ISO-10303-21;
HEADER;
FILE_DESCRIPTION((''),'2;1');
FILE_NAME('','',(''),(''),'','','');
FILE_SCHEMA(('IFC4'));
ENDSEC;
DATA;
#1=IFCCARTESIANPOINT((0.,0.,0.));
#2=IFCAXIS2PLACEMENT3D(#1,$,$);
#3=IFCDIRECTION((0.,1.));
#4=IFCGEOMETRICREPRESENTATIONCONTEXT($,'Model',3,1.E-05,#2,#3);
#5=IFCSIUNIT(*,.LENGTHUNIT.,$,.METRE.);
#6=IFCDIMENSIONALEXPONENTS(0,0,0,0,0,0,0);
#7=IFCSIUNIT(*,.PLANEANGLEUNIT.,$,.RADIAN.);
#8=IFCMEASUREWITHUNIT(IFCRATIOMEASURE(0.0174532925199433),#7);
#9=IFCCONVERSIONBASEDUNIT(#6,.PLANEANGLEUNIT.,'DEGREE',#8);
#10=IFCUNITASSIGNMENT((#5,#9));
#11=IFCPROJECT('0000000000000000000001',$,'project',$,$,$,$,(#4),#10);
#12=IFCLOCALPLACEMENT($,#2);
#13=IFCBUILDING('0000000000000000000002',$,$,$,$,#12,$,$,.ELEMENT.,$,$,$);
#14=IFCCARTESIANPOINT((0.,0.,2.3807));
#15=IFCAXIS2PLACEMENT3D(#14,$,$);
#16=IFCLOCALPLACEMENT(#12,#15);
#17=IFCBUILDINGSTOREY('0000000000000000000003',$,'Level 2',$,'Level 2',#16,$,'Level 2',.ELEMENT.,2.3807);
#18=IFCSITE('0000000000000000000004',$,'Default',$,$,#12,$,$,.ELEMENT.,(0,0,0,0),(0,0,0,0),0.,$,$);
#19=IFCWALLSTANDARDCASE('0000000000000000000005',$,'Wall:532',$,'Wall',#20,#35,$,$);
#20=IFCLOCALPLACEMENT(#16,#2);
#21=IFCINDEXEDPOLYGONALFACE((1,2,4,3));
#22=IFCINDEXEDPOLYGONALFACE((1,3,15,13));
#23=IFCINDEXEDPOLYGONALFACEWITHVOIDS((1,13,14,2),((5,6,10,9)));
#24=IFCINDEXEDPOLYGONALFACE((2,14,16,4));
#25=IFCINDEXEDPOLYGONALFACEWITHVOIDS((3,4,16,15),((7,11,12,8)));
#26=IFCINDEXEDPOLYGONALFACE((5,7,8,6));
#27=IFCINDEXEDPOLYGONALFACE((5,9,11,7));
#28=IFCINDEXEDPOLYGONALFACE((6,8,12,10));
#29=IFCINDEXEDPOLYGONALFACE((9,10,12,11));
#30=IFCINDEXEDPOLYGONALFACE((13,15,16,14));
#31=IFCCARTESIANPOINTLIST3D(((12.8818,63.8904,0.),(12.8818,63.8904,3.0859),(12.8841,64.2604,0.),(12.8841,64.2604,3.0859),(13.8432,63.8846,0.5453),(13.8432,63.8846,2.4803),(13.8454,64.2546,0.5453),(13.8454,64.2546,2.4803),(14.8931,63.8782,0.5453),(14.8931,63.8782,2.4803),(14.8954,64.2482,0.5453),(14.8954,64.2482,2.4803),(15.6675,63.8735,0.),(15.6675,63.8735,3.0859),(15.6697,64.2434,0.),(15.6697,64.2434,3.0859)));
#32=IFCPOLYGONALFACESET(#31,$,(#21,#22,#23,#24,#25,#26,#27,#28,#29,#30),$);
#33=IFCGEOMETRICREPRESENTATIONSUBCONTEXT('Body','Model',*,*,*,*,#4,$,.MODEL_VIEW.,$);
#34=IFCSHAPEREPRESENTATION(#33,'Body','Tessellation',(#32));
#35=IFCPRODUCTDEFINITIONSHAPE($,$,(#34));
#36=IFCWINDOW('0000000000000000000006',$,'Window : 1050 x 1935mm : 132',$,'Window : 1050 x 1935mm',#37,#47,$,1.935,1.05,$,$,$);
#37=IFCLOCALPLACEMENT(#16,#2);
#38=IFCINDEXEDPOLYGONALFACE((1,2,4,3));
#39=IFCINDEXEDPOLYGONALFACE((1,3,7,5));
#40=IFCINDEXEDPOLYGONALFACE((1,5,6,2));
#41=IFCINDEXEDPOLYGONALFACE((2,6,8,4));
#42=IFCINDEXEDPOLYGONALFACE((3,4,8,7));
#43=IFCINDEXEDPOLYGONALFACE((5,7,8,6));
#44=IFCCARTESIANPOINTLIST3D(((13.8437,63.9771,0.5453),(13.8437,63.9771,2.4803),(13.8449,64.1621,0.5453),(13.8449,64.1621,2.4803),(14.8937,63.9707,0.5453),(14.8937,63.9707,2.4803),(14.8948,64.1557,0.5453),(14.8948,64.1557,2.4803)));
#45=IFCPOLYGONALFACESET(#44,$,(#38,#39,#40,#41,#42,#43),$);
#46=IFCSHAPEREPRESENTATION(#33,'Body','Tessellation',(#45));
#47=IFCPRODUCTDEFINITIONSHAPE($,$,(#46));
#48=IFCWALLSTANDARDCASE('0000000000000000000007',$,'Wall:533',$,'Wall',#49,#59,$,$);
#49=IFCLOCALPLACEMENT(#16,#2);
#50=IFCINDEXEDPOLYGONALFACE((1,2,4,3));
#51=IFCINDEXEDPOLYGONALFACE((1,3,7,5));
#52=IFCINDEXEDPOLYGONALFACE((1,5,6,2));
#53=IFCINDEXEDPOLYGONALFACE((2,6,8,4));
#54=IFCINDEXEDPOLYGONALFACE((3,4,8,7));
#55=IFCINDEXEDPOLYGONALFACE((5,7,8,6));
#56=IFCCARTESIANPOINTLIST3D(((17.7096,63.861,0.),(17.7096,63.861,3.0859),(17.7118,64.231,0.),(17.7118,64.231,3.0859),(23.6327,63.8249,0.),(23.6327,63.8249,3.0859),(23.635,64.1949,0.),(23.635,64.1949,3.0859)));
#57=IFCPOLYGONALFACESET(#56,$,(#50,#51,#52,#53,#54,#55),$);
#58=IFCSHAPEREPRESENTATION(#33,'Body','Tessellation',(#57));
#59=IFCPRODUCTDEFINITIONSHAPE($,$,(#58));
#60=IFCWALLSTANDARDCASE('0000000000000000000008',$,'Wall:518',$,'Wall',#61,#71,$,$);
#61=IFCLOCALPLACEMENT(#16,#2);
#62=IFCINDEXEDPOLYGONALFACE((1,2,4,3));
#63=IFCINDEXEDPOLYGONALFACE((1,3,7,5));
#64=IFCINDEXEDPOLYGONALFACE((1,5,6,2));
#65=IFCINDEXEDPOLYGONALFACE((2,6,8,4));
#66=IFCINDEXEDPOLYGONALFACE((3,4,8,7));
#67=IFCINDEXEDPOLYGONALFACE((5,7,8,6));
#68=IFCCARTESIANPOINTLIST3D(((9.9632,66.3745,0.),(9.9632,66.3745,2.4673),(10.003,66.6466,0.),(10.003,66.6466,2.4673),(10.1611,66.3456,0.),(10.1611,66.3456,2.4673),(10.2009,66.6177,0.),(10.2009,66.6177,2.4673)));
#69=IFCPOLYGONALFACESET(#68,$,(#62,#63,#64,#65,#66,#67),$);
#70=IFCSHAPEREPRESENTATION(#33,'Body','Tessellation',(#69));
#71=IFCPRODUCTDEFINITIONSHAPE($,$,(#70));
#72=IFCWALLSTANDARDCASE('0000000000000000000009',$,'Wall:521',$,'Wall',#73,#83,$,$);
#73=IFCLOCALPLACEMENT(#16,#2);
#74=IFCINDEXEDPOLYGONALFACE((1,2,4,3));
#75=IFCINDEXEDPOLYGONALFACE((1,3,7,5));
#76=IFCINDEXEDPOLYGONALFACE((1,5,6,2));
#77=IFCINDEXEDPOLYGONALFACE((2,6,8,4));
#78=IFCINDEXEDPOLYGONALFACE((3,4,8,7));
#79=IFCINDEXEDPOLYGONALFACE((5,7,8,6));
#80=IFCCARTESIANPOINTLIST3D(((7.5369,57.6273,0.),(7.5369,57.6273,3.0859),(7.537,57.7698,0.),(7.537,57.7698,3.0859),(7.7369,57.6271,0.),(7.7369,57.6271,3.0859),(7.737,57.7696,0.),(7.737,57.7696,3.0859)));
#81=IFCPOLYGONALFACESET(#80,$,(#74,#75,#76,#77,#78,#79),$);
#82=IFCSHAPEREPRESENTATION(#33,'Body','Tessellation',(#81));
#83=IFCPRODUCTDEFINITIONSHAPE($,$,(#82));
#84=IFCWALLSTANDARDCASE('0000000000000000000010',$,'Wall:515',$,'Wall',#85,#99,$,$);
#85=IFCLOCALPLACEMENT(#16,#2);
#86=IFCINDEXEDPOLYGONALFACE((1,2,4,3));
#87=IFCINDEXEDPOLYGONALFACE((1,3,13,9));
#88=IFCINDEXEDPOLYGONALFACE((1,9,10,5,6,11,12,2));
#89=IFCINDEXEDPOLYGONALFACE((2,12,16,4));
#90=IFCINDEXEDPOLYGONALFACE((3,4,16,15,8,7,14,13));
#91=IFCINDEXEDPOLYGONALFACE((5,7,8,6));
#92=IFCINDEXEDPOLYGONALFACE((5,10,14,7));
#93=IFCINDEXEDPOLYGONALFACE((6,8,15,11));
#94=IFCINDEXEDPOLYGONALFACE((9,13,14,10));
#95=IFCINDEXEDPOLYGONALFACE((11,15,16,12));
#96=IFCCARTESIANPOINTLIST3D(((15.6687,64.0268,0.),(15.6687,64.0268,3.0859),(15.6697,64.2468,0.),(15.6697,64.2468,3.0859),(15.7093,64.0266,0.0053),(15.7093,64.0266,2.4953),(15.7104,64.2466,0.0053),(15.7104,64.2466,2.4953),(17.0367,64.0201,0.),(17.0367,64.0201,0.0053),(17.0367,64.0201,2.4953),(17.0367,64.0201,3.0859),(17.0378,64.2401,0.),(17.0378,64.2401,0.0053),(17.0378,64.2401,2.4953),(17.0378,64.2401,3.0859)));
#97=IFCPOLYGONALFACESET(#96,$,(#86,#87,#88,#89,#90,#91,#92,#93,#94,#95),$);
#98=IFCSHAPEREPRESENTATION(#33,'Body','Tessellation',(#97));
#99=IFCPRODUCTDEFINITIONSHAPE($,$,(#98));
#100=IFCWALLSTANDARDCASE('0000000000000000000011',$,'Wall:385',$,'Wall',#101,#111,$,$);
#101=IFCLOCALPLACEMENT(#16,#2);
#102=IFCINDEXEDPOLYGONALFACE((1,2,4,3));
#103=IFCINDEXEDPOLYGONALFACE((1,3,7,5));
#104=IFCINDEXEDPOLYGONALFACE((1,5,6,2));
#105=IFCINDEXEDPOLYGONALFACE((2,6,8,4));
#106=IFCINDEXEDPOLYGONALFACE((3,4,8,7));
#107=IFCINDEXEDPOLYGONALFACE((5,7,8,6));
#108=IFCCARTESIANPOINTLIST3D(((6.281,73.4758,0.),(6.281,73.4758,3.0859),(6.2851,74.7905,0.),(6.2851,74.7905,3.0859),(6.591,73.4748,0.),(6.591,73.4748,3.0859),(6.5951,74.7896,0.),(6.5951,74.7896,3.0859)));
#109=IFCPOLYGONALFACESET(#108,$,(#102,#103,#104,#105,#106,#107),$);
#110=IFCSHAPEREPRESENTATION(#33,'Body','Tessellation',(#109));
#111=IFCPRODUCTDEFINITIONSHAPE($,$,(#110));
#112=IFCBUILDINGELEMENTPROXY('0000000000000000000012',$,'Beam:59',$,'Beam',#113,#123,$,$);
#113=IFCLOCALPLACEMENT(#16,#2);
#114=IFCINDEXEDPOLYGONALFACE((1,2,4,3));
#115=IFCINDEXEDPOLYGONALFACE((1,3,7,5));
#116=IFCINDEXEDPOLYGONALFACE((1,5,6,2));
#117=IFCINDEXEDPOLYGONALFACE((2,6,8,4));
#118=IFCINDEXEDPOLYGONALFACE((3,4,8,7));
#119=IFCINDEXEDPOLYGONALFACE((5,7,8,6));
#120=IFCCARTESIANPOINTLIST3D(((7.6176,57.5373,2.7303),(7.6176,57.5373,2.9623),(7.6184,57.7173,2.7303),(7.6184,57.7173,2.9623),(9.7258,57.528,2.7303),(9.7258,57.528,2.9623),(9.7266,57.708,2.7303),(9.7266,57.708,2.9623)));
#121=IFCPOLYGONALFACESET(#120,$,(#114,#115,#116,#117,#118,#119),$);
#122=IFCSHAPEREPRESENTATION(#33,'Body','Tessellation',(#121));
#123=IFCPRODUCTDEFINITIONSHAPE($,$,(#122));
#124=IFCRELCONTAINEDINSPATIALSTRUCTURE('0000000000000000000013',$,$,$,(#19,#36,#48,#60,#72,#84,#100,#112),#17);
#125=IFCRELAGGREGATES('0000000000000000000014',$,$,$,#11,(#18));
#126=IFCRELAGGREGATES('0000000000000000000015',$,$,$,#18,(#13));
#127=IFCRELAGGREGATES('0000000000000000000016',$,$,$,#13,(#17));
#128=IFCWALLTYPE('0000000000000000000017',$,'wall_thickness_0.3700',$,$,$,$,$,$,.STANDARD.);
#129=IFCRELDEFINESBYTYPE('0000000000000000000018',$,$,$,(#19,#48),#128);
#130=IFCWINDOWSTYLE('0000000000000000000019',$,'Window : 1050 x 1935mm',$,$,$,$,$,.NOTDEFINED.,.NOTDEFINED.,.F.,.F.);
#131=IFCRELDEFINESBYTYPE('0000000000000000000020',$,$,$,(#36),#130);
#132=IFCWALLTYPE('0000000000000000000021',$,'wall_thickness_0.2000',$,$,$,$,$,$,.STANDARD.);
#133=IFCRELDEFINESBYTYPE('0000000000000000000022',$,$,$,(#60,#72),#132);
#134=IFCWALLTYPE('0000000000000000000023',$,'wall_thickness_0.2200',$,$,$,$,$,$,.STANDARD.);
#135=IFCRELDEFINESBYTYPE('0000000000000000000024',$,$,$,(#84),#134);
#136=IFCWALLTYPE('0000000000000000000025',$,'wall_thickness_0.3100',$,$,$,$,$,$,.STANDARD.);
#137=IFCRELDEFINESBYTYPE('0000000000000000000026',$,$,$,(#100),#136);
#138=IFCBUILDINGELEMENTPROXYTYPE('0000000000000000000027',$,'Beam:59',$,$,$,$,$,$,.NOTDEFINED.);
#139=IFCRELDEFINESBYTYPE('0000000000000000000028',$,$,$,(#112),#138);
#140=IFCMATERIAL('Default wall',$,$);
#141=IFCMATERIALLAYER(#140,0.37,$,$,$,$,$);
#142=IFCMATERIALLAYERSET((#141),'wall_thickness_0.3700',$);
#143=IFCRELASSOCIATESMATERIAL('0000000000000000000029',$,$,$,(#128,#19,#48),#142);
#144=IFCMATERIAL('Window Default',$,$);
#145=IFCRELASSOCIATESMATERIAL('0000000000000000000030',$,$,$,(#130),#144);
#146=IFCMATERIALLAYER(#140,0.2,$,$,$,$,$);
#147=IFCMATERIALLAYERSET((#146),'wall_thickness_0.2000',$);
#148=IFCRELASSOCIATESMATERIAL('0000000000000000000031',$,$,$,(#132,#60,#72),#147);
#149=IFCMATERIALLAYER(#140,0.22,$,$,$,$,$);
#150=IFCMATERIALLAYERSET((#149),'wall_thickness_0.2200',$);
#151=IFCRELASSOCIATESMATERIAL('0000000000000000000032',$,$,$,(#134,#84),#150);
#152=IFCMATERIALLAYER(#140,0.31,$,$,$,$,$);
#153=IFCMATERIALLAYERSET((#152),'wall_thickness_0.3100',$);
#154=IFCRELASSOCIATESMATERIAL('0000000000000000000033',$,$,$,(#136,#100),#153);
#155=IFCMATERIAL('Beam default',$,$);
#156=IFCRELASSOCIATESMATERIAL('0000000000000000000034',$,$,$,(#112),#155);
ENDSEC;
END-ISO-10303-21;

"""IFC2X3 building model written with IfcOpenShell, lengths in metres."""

from ifc_helpers import new_model, entity, si_unit, converted_unit, direction, frame, frame_2d, origin, origin_2d_with_axis, place, context, subcontext, project, spatial, polyline, rectangle, outline, extrude, source, transform, mapped, material, layer, layer_set, layer_usage, type_object, type_shapes, element, fill, save


model = new_model("IFC2X3")

# Units and contexts
model_context = context("Model", 3, precision=1e-05, world=origin(), true_north=direction((0.0, 1.0)))
body_context = subcontext(model_context, "Body", "Model", "MODEL_VIEW")
ifc_project = project(units=[si_unit("LENGTHUNIT", "METRE"), converted_unit("PLANEANGLEUNIT", "DEGREE", entity("IfcRatioMeasure", 0.0174532925199433), si_unit("PLANEANGLEUNIT", "RADIAN"), dimensions=[0, 0, 0, 0, 0, 0, 0])], contexts=[model_context])

# Site, building, storey
placement_1 = place(None, origin())
site = spatial("IfcSite", under=ifc_project, at=placement_1, Name="Default", CompositionType="ELEMENT", RefLatitude=(0, 0, 0, 0), RefLongitude=(0, 0, 0, 0), RefElevation=0.0)
building = spatial("IfcBuilding", under=site, at=placement_1, CompositionType="ELEMENT")
storey_placement = place(placement_1, frame((0.0, 0.0, 2.3807)))
storey = spatial("IfcBuildingStorey", under=building, at=storey_placement, Name="Level 2", ObjectType="Level 2", LongName="Level 2", CompositionType="ELEMENT", Elevation=2.3807)

# Shared definitions
ifc_material_1 = material(Name="Default wall")

# Shared definitions
ifc_material_2 = material(Name="Window Default")

# Shared definitions
ifc_layer_1 = layer(ifc_material_1, 0.37)
ifc_layer_set_1 = layer_set([ifc_layer_1], Name="wall_thickness_0.3700")
ifc_layer_usage_1 = layer_usage(ifc_layer_set_1, "AXIS2", "POSITIVE", -0.185)
wall_type_1 = type_object("IfcWallType", Name="wall_thickness_0.3700", PredefinedType="STANDARD", material=ifc_layer_set_1)

# Wall, opening, window
wall_1_placement = place(storey_placement, frame((12.8829, 64.0754, 0.0), z_axis=(0.0, 0.0, 1.0), x_axis=(0.999981, -0.006097, 0.0)))
wall_1 = element("IfcWallStandardCase", 1, at=wall_1_placement, inside=storey, type_object=wall_type_1, material=ifc_layer_usage_1, Name="Wall:532", ObjectType="Wall", context=body_context, shape_type="SweptSolid", body=[
    extrude(outline(polyline([(2.7857, -0.185), (2.7857, 0.185), (0.0, 0.185), (0.0, -0.185), (2.7857, -0.185)])), origin(), (0.0, 0.0, 1.0), 3.0859),
])
opening_1_placement = place(wall_1_placement, frame((0.9614, -0.185, 0.5453)))
opening_1 = element("IfcOpeningElement", 2, at=opening_1_placement, cuts=wall_1, ObjectType="Opening", context=body_context, shape_type="SweptSolid", body=[
    extrude(rectangle(XDim=1.05, YDim=1.935, at=frame_2d((0.9675, 0.525), x_axis=(0.0, 1.0))), frame((0.0, 0.0, 0.0), z_axis=(0.0, 1.0, 0.0), x_axis=(0.0, 0.0, 1.0)), (0.0, 0.0, 1.0), 0.37),
])
window_style_1 = type_object("IfcWindowStyle", Name="Window : 1050 x 1935mm", ConstructionType="NOTDEFINED", OperationType="NOTDEFINED", ParameterTakesPrecedence=False, Sizeable=False, material=ifc_material_2)
shared_shape_1 = source(origin(), body_context, "Body", "SweptSolid", [
    extrude(rectangle(XDim=0.185, YDim=1.05, at=origin_2d_with_axis()), frame((0.525, 0.185, 0.0), z_axis=(0.0, 0.0, 1.0), x_axis=(0.0, 1.0, 0.0)), (0.0, 0.0, 1.0), 1.935),
])
type_shapes(window_style_1, [shared_shape_1])
window_1_placement = place(opening_1_placement, origin())
window_1 = element("IfcWindow", 3, at=window_1_placement, inside=storey, type_object=window_style_1, Name="Window : 1050 x 1935mm : 132", ObjectType="Window : 1050 x 1935mm", OverallHeight=1.935, OverallWidth=1.05, context=body_context, shape_type="MappedRepresentation", body=[
    mapped(shared_shape_1, transform((0.0, 0.0, 0.0), scale=1.0)),
])
fill(opening_1, window_1)

# Walls
wall_2_placement = place(storey_placement, frame((17.7107, 64.046, 0.0), z_axis=(0.0, 0.0, 1.0), x_axis=(0.999981, -0.006095, 0.0)))
element("IfcWallStandardCase", 4, at=wall_2_placement, inside=storey, type_object=wall_type_1, material=ifc_layer_usage_1, Name="Wall:533", ObjectType="Wall", context=body_context, shape_type="SweptSolid", body=[
    extrude(outline(polyline([(5.9233, -0.185), (5.9233, 0.185), (0.0, 0.185), (0.0, -0.185), (5.9233, -0.185)])), origin(), (0.0, 0.0, 1.0), 3.0859),
])
ifc_layer_2 = layer(ifc_material_1, 0.2)
ifc_layer_set_2 = layer_set([ifc_layer_2], Name="wall_thickness_0.2000")
ifc_layer_usage_2 = layer_usage(ifc_layer_set_2, "AXIS2", "POSITIVE", -0.1)
wall_type_2 = type_object("IfcWallType", Name="wall_thickness_0.2000", PredefinedType="STANDARD", material=ifc_layer_set_2)
wall_3_placement = place(storey_placement, frame((10.102, 66.6322, 0.0), z_axis=(0.0, 0.0, 1.0), x_axis=(-0.144799, -0.989461, 0.0)))
element("IfcWallStandardCase", 5, at=wall_3_placement, inside=storey, type_object=wall_type_2, material=ifc_layer_usage_2, Name="Wall:518", ObjectType="Wall", context=body_context, shape_type="SweptSolid", body=[
    extrude(outline(polyline([(0.275, -0.1), (0.275, 0.1), (0.0, 0.1), (0.0, -0.1), (0.275, -0.1)])), origin(), (0.0, 0.0, 1.0), 2.4673),
])
wall_4_placement = place(storey_placement, frame((7.637, 57.7697, 0.0), z_axis=(0.0, 0.0, 1.0), x_axis=(-0.001064, -0.999999, 0.0)))
element("IfcWallStandardCase", 6, at=wall_4_placement, inside=storey, type_object=wall_type_2, material=ifc_layer_usage_2, Name="Wall:521", ObjectType="Wall", context=body_context, shape_type="SweptSolid", body=[
    extrude(outline(polyline([(0.1425, -0.1), (0.1425, 0.1), (0.0, 0.1), (0.0, -0.1), (0.1425, -0.1)])), origin(), (0.0, 0.0, 1.0), 3.0859),
])

# Wall, opening
ifc_layer_3 = layer(ifc_material_1, 0.22)
ifc_layer_set_3 = layer_set([ifc_layer_3], Name="wall_thickness_0.2200")
ifc_layer_usage_3 = layer_usage(ifc_layer_set_3, "AXIS2", "POSITIVE", -0.11)
wall_type_3 = type_object("IfcWallType", Name="wall_thickness_0.2200", PredefinedType="STANDARD", material=ifc_layer_set_3)
wall_5_placement = place(storey_placement, frame((15.6692, 64.1368, 0.0), z_axis=(0.0, 0.0, 1.0), x_axis=(0.999988, -0.004896, 0.0)))
wall_5 = element("IfcWallStandardCase", 7, at=wall_5_placement, inside=storey, type_object=wall_type_3, material=ifc_layer_usage_3, Name="Wall:515", ObjectType="Wall", context=body_context, shape_type="SweptSolid", body=[
    extrude(outline(polyline([(1.368, -0.11), (1.368, 0.11), (0.0, 0.11), (0.0, -0.11), (1.368, -0.11)])), origin(), (0.0, 0.0, 1.0), 3.0859),
])
opening_2_placement = place(wall_5_placement, frame((0.0407, -0.11, 0.0053)))
element("IfcOpeningElement", 8, at=opening_2_placement, cuts=wall_5, ObjectType="Opening", context=body_context, shape_type="SweptSolid", body=[
    extrude(rectangle(XDim=1.975, YDim=2.49, at=frame_2d((1.245, 0.9875), x_axis=(0.0, 1.0))), frame((0.0, 0.0, 0.0), z_axis=(0.0, 1.0, 0.0), x_axis=(0.0, 0.0, 1.0)), (0.0, 0.0, 1.0), 0.22),
])

# Wall
ifc_layer_4 = layer(ifc_material_1, 0.31)
ifc_layer_set_4 = layer_set([ifc_layer_4], Name="wall_thickness_0.3100")
ifc_layer_usage_4 = layer_usage(ifc_layer_set_4, "AXIS2", "POSITIVE", -0.155)
wall_type_4 = type_object("IfcWallType", Name="wall_thickness_0.3100", PredefinedType="STANDARD", material=ifc_layer_set_4)
wall_6_placement = place(storey_placement, frame((6.4401, 74.7901, 0.0), z_axis=(0.0, 0.0, 1.0), x_axis=(-0.003086, -0.999995, 0.0)))
element("IfcWallStandardCase", 9, at=wall_6_placement, inside=storey, type_object=wall_type_4, material=ifc_layer_usage_4, Name="Wall:385", ObjectType="Wall", context=body_context, shape_type="SweptSolid", body=[
    extrude(outline(polyline([(1.3148, -0.155), (1.3148, 0.155), (0.0, 0.155), (0.0, -0.155), (1.3148, -0.155)])), origin(), (0.0, 0.0, 1.0), 3.0859),
])

# Building element proxy
ifc_material_3 = material(Name="Beam default")
building_element_proxy_type = type_object("IfcBuildingElementProxyType", Name="Beam:59", PredefinedType="NOTDEFINED")
shared_shape_2 = source(origin(), body_context, "Body", "SweptSolid", [
    extrude(outline(polyline([(2.1083, -0.09), (2.1083, 0.09), (0.0, 0.09), (0.0, -0.09), (2.1083, -0.09)])), origin(), (0.0, 0.0, 1.0), 0.232),
])
type_shapes(building_element_proxy_type, [shared_shape_2])
placement_2 = place(placement_1, frame((0.0, 0.0, 5.111)))
proxy_placement = place(placement_2, frame((7.618, 57.6273, 0.0), z_axis=(0.0, 0.0, 1.0), x_axis=(0.99999, -0.004402, 0.0)))
element("IfcBuildingElementProxy", 10, at=proxy_placement, inside=storey, type_object=building_element_proxy_type, material=ifc_material_3, Name="Beam:59", ObjectType="Beam", context=body_context, shape_type="MappedRepresentation", body=[
    mapped(shared_shape_2, transform((0.0, 0.0, 0.0), scale=1.0)),
])

save(model, "model.ifc")
